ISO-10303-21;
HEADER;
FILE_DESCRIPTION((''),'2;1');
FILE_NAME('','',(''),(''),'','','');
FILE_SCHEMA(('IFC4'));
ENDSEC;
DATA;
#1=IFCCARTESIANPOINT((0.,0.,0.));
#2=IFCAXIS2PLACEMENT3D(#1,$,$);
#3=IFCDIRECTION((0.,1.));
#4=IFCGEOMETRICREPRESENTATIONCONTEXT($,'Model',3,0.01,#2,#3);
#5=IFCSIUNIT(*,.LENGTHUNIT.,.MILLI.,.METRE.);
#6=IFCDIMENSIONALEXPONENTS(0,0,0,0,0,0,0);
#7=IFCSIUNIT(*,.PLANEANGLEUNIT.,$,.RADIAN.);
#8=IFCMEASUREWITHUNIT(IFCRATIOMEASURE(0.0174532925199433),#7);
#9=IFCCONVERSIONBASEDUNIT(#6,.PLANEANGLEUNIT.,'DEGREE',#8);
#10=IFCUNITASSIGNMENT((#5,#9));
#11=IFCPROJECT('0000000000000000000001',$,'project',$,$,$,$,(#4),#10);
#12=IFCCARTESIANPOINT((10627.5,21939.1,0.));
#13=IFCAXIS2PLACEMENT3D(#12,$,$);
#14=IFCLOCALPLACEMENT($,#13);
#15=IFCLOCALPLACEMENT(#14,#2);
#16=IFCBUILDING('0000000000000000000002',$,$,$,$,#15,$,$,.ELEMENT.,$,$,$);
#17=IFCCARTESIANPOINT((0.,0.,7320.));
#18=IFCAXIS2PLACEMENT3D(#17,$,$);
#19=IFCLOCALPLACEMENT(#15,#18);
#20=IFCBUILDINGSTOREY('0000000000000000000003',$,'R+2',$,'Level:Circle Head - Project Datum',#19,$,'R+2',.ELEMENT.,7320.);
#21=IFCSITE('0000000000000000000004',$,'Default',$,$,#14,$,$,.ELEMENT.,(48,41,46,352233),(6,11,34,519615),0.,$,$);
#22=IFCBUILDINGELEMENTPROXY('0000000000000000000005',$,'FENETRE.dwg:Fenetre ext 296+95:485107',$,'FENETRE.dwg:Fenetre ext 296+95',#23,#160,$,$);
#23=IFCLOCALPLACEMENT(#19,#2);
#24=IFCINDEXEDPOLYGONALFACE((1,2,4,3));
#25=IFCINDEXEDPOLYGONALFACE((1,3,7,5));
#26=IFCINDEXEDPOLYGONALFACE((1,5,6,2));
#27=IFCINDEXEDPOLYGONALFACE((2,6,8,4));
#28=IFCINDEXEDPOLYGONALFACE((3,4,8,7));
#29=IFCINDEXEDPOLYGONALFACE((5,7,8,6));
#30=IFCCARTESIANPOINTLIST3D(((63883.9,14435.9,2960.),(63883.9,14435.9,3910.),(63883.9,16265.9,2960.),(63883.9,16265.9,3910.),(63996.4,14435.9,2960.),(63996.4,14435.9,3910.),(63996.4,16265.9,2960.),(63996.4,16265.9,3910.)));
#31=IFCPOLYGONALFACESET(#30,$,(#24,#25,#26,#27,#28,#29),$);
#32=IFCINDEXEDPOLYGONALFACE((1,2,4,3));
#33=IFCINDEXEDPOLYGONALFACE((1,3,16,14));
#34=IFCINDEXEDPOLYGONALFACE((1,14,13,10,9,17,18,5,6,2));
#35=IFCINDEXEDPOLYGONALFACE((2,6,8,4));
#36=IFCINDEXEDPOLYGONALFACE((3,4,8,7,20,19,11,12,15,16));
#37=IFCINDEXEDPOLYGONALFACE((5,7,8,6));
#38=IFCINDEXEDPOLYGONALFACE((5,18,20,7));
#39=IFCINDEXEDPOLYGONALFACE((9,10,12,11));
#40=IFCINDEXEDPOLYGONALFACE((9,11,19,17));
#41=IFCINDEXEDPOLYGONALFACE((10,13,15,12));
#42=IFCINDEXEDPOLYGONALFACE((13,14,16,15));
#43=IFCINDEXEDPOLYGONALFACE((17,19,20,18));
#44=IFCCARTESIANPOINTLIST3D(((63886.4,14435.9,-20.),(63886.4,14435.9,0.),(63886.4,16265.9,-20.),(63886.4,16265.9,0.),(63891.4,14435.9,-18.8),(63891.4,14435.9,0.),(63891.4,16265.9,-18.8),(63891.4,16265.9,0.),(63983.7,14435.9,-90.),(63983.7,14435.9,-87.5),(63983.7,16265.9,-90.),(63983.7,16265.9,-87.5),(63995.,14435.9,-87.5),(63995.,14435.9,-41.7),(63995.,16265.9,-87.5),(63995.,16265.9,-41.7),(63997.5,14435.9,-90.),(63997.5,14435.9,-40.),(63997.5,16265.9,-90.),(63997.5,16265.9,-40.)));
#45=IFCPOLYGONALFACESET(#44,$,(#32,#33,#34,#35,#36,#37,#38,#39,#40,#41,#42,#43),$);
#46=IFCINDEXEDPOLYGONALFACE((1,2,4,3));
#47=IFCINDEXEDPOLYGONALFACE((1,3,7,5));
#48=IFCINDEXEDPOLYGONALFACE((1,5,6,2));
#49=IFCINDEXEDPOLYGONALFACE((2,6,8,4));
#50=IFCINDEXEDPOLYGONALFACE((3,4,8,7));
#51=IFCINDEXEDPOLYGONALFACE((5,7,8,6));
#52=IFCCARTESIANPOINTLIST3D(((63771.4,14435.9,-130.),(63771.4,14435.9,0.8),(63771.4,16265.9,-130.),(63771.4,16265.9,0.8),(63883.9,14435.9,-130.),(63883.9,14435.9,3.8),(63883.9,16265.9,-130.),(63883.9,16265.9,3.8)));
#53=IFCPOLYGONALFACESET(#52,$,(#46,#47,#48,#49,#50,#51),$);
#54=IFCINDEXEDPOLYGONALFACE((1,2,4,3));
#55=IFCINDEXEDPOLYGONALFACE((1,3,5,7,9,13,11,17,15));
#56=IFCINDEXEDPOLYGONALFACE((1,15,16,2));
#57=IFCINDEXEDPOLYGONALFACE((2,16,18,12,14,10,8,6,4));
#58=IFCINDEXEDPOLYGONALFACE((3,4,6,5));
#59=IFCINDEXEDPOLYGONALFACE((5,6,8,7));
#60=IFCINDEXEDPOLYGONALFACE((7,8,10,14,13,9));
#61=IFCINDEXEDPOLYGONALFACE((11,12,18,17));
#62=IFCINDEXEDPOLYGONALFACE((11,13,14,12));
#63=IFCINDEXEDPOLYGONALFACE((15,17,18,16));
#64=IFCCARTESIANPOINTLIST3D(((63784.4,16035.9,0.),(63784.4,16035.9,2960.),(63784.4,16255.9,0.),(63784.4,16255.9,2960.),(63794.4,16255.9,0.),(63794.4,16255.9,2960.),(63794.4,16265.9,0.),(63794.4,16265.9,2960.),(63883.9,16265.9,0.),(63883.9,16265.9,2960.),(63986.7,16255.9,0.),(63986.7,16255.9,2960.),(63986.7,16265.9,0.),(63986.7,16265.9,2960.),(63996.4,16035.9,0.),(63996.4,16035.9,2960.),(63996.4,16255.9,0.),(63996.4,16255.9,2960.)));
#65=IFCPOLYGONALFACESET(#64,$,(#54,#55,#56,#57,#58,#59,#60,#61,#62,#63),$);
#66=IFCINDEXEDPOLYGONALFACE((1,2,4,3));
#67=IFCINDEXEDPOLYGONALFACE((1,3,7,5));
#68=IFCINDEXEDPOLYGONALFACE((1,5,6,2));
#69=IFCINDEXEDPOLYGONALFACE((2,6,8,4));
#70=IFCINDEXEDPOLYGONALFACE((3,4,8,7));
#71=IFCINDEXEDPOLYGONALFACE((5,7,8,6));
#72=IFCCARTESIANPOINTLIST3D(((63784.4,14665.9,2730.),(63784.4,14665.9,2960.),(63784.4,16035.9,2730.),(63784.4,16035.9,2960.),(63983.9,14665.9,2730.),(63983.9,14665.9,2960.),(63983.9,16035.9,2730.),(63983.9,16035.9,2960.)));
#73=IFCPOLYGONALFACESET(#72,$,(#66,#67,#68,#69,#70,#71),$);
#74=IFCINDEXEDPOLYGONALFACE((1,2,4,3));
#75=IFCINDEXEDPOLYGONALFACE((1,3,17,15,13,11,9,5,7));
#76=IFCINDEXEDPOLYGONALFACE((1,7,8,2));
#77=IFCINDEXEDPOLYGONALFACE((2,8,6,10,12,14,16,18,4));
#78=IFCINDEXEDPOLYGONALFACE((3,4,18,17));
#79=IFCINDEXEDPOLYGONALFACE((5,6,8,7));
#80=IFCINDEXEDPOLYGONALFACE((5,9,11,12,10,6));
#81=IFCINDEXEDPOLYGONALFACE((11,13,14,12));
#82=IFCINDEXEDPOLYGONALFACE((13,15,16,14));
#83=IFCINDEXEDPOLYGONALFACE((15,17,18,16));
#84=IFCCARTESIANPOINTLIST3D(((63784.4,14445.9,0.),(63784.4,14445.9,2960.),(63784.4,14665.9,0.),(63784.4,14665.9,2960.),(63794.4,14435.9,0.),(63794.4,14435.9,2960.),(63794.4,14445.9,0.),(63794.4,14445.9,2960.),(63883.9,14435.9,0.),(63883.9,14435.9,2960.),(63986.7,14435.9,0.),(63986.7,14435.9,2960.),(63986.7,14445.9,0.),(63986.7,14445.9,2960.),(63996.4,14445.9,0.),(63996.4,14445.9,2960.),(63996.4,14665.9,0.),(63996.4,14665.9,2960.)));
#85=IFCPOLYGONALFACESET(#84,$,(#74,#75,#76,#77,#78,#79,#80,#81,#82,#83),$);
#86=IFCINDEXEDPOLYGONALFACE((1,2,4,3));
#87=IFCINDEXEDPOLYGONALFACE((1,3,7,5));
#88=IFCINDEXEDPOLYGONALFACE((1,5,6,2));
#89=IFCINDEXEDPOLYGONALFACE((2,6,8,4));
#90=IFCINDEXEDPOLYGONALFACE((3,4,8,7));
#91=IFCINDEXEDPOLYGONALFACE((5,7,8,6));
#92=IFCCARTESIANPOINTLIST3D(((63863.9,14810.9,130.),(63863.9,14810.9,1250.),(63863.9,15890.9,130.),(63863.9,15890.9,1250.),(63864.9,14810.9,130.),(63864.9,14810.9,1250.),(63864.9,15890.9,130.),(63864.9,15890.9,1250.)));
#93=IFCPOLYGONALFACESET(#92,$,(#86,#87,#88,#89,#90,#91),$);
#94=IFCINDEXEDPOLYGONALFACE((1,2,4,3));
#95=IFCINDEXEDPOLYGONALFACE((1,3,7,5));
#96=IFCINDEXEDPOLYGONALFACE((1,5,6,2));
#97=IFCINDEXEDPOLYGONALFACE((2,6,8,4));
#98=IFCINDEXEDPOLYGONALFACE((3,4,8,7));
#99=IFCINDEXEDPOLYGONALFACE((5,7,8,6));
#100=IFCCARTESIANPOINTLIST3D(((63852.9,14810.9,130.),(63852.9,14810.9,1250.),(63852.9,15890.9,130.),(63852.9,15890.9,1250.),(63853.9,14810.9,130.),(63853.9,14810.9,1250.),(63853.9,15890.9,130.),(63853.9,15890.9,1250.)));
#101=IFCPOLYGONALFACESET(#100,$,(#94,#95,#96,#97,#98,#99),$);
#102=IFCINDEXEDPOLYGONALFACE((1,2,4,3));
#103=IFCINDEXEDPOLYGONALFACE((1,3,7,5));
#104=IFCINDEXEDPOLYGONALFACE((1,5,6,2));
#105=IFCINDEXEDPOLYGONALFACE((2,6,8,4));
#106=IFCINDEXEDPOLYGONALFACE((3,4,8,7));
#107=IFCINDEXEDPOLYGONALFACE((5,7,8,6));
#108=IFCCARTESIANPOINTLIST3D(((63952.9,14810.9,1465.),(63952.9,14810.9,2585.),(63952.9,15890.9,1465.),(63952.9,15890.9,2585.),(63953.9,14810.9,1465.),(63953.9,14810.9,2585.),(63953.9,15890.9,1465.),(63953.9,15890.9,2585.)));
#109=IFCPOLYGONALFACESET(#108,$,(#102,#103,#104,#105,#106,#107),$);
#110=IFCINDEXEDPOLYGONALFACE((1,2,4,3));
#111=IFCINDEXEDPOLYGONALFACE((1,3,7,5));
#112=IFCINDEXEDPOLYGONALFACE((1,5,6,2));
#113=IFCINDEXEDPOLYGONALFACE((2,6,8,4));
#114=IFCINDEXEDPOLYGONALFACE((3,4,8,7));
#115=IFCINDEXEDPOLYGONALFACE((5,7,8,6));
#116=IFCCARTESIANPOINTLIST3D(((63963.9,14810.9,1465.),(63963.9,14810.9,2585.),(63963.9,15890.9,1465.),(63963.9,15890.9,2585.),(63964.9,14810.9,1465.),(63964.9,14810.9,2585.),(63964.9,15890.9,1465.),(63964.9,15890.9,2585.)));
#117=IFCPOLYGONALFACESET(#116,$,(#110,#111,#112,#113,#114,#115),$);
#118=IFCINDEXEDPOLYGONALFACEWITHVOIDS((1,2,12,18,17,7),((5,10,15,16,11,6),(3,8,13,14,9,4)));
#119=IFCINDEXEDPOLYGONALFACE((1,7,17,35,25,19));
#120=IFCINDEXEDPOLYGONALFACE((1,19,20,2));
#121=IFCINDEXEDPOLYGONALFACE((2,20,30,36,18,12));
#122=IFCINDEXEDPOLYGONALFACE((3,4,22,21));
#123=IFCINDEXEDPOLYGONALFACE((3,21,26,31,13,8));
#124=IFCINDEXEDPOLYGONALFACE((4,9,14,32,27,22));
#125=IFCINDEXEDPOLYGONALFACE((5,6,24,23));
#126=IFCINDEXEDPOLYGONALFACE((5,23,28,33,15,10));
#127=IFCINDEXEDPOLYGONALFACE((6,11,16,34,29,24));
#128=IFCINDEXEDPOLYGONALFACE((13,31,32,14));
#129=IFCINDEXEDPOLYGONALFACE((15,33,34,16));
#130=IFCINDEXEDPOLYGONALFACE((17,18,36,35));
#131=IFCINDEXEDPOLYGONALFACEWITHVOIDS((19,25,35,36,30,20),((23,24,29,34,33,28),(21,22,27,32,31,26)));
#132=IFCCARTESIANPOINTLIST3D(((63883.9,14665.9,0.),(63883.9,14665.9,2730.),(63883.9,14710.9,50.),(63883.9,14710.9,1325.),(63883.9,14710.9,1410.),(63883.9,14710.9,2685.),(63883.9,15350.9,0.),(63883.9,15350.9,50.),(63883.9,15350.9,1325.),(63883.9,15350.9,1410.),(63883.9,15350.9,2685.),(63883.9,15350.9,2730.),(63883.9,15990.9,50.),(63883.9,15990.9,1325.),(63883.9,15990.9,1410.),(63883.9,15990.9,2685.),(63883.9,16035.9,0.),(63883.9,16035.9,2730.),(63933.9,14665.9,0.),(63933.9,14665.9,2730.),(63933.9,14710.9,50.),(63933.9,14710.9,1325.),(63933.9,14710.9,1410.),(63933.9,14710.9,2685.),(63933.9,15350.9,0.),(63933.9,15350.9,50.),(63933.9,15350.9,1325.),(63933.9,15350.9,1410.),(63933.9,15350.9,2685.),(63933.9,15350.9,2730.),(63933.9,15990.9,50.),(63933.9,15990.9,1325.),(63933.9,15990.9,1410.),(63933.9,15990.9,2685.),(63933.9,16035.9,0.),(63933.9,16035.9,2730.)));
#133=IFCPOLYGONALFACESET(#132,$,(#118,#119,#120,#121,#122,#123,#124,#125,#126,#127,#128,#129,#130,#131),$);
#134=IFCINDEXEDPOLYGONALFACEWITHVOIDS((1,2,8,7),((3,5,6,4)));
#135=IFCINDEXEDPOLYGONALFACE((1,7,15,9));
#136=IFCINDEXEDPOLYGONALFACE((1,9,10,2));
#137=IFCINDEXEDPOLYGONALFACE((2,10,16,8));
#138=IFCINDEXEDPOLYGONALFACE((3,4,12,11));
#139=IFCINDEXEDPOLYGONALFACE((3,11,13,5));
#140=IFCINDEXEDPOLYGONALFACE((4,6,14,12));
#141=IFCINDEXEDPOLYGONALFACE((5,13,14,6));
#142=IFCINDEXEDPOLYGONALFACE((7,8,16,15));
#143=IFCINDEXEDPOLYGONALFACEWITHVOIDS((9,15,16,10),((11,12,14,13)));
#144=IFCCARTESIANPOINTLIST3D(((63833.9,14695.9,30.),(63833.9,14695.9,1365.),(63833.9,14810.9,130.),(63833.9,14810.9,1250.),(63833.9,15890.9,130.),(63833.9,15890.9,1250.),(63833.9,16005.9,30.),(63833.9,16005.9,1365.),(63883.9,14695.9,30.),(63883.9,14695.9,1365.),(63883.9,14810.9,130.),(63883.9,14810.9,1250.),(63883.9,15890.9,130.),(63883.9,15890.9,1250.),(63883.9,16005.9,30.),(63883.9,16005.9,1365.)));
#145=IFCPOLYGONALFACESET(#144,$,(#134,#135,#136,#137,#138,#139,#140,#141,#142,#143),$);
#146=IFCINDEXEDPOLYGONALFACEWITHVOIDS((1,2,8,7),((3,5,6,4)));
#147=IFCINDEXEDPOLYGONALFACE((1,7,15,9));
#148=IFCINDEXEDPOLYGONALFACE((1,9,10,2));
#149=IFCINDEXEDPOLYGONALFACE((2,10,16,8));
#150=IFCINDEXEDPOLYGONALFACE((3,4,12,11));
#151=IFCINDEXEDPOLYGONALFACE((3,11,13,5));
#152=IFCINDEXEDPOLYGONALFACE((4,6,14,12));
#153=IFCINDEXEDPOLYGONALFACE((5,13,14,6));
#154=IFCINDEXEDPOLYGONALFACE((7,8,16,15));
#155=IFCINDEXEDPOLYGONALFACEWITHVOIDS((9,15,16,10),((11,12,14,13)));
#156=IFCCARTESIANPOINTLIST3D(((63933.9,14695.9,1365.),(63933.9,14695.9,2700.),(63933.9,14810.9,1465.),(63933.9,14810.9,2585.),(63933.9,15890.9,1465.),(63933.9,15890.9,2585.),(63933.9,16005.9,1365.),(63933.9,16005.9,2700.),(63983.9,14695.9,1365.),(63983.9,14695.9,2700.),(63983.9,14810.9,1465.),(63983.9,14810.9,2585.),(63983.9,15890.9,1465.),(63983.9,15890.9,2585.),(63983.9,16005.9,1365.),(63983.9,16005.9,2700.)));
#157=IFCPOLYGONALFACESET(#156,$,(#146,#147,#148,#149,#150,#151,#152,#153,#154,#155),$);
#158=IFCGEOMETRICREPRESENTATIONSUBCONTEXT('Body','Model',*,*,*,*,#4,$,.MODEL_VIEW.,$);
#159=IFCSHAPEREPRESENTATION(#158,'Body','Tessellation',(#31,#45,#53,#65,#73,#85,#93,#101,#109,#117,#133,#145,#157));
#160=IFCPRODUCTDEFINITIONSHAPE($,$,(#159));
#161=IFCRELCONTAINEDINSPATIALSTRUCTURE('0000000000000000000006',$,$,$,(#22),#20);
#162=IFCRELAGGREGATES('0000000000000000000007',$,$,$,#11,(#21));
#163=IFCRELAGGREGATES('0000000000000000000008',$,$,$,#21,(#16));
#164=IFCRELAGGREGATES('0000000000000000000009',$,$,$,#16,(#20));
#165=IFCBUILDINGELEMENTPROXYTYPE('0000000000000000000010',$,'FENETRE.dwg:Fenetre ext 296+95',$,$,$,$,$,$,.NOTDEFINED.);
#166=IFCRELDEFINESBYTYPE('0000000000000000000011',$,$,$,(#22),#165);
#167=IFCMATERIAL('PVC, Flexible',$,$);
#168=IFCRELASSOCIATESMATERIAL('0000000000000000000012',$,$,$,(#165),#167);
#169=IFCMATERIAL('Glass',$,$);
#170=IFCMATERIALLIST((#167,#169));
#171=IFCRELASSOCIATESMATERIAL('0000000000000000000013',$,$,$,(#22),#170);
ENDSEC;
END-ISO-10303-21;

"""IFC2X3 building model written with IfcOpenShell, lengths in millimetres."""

from ifc_helpers import new_model, entity, si_unit, converted_unit, direction, frame, frame_2d, origin, origin_2d_with_axis, place, context, subcontext, project, spatial, polyline, rectangle, outline, extrude, source, transform, mapped, material, material_list, type_object, type_shapes, element, save


model = new_model("IFC2X3")

# Units and contexts
model_context = context("Model", 3, precision=0.01, world=origin(), true_north=direction((0.0, 1.0)))
body_context = subcontext(model_context, "Body", "Model", "MODEL_VIEW")
ifc_project = project(units=[si_unit("LENGTHUNIT", "METRE", prefix="MILLI"), converted_unit("PLANEANGLEUNIT", "DEGREE", entity("IfcRatioMeasure", 0.0174532925199433), si_unit("PLANEANGLEUNIT", "RADIAN"), dimensions=[0, 0, 0, 0, 0, 0, 0])], contexts=[model_context])

# Site, building, storey
site_placement = place(None, frame((10627.5, 21939.1, 0.0)))
site = spatial("IfcSite", under=ifc_project, at=site_placement, Name="Default", CompositionType="ELEMENT", RefLatitude=(48, 41, 46, 352233), RefLongitude=(6, 11, 34, 519615), RefElevation=0.0)
building_placement = place(site_placement, origin())
building = spatial("IfcBuilding", under=site, at=building_placement, CompositionType="ELEMENT")
storey_placement = place(building_placement, frame((0.0, 0.0, 7320.0)))
storey = spatial("IfcBuildingStorey", under=building, at=storey_placement, Name="R+2", ObjectType="Level:Circle Head - Project Datum", LongName="R+2", CompositionType="ELEMENT", Elevation=7320.0)

# Building element proxy
ifc_material_1 = material(Name="PVC, Flexible")
ifc_material_2 = material(Name="Glass")
ifc_material_list_1 = material_list([ifc_material_1, ifc_material_2])
building_element_proxy_type_1 = type_object("IfcBuildingElementProxyType", Name="FENETRE.dwg:Fenetre ext 296+95", PredefinedType="NOTDEFINED", material=ifc_material_1)
shared_shape_1 = source(origin(), body_context, "Body", "SweptSolid", [
    extrude(rectangle(XDim=112.5, YDim=1830.0, at=origin_2d_with_axis()), frame((-10.4, -56.3, 2960.0), z_axis=(0.0, 0.0, 1.0), x_axis=(0.0, 1.0, 0.0)), (0.0, 0.0, 1.0), 950.0),
    extrude(outline(polyline([(27.5, -64.4), (47.5, -64.4), (47.5, -59.4), (28.8, -59.4), (7.5, 46.7), (-42.5, 46.7), (-42.5, 32.9), (-40.0, 32.9), (-40.0, 44.2), (5.8, 44.2), (27.5, -64.4)])), frame((-925.4, -66.9, -47.5), z_axis=(1.0, 0.0, 0.0), x_axis=(0.0, 0.0, 1.0)), (0.0, 0.0, 1.0), 1830.0),
    extrude(outline(polyline([(-54.5, -66.1), (58.0, -66.1), (54.5, 67.6), (-58.0, 64.6), (-54.5, -66.1)])), frame((-925.4, 56.3, -63.8), z_axis=(1.0, 0.0, 0.0), x_axis=(0.0, -0.999645, 0.02665)), (0.0, 0.0, 1.0), 1830.0),
    extrude(outline(polyline([(-97.0, -55.6), (5.9, -55.6), (95.4, -55.6), (95.4, -45.6), (105.4, -45.6), (105.4, 174.4), (-106.6, 174.4), (-106.6, -45.6), (-97.0, -45.6), (-97.0, -55.6)])), frame((849.0, -5.9, 0.0), z_axis=(0.0, 0.0, 1.0), x_axis=(0.0, 1.0, 0.0)), (0.0, 0.0, 1.0), 2960.0),
    extrude(rectangle(XDim=1370.0, YDim=199.5, at=origin_2d_with_axis()), frame((-10.4, -0.3, 2730.0), z_axis=(0.0, 0.0, 1.0), x_axis=(-1.0, 0.0, 0.0)), (0.0, 0.0, 1.0), 230.0),
    extrude(outline(polyline([(-55.6, 97.0), (-55.6, -5.9), (-55.6, -95.4), (-45.6, -95.4), (-45.6, -105.4), (174.4, -105.4), (174.4, 106.6), (-45.6, 106.6), (-45.6, 97.0), (-55.6, 97.0)])), frame((-869.9, -5.9, 0.0), z_axis=(0.0, 0.0, -1.0), x_axis=(1.0, 0.0, 0.0)), (0.0, 0.0, -1.0), 2960.0),
    extrude(rectangle(XDim=1080.0, YDim=1.0, at=origin_2d_with_axis()), frame((-10.4, 19.5, 130.0), z_axis=(0.0, 0.0, 1.0), x_axis=(-1.0, 0.0, 0.0)), (0.0, 0.0, 1.0), 1120.0),
    extrude(rectangle(XDim=1080.0, YDim=1.0, at=origin_2d_with_axis()), frame((-10.4, 30.5, 130.0), z_axis=(0.0, 0.0, 1.0), x_axis=(-1.0, 0.0, 0.0)), (0.0, 0.0, 1.0), 1120.0),
    extrude(rectangle(XDim=1080.0, YDim=1.0, at=frame_2d((0.0, 0.0), x_axis=(1.0, 0.0))), frame((-10.4, -69.5, 1465.0), z_axis=(0.0, 0.0, 1.0), x_axis=(-1.0, 0.0, 0.0)), (0.0, 0.0, 1.0), 1120.0),
    extrude(rectangle(XDim=1080.0, YDim=1.0, at=frame_2d((0.0, 0.0), x_axis=(1.0, 0.0))), frame((-10.4, -80.5, 1465.0), z_axis=(0.0, 0.0, 1.0), x_axis=(-1.0, 0.0, 0.0)), (0.0, 0.0, 1.0), 1120.0),
    extrude(outline(polyline([(-685.0, -1365.0), (0.0, -1365.0), (685.0, -1365.0), (685.0, 1365.0), (0.0, 1365.0), (-685.0, 1365.0), (-685.0, -1365.0)]), holes=[polyline([(-640.0, -1320.0), (-640.0, -45.0), (0.0, -45.0), (640.0, -45.0), (640.0, -1320.0), (0.0, -1320.0), (-640.0, -1320.0)]), polyline([(-640.0, 40.0), (-640.0, 1315.0), (0.0, 1315.0), (640.0, 1315.0), (640.0, 40.0), (0.0, 40.0), (-640.0, 40.0)])]), frame((-10.4, -50.0, 1365.0), z_axis=(0.0, 1.0, 0.0), x_axis=(1.0, 0.0, 0.0)), (0.0, 0.0, 1.0), 50.0),
    extrude(outline(polyline([(-655.0, -667.5), (655.0, -667.5), (655.0, 667.5), (-655.0, 667.5), (-655.0, -667.5)]), holes=[polyline([(-540.0, 552.5), (540.0, 552.5), (540.0, -567.5), (-540.0, -567.5), (-540.0, 552.5)])]), frame((-10.4, 0.0, 697.5), z_axis=(0.0, 1.0, 0.0), x_axis=(-1.0, 0.0, 0.0)), (0.0, 0.0, 1.0), 50.0),
    extrude(outline(polyline([(-655.0, -667.5), (655.0, -667.5), (655.0, 667.5), (-655.0, 667.5), (-655.0, -667.5)]), holes=[polyline([(-540.0, 552.5), (540.0, 552.5), (540.0, -567.5), (-540.0, -567.5), (-540.0, 552.5)])]), frame((-10.4, -100.0, 2032.5), z_axis=(0.0, 1.0, 0.0), x_axis=(-1.0, 0.0, 0.0)), (0.0, 0.0, 1.0), 50.0),
])
type_shapes(building_element_proxy_type_1, [shared_shape_1])
proxy_1_placement = place(storey_placement, frame((63883.9, 15361.3, 0.0), z_axis=(0.0, 0.0, 1.0), x_axis=(0.0, 1.0, 0.0)))
element("IfcBuildingElementProxy", 1, at=proxy_1_placement, inside=storey, type_object=building_element_proxy_type_1, material=ifc_material_list_1, Name="FENETRE.dwg:Fenetre ext 296+95:485107", ObjectType="FENETRE.dwg:Fenetre ext 296+95", context=body_context, shape_type="MappedRepresentation", body=[
    mapped(shared_shape_1, transform((0.0, 0.0, 0.0), scale=1.0)),
])

save(model, "model.ifc")
